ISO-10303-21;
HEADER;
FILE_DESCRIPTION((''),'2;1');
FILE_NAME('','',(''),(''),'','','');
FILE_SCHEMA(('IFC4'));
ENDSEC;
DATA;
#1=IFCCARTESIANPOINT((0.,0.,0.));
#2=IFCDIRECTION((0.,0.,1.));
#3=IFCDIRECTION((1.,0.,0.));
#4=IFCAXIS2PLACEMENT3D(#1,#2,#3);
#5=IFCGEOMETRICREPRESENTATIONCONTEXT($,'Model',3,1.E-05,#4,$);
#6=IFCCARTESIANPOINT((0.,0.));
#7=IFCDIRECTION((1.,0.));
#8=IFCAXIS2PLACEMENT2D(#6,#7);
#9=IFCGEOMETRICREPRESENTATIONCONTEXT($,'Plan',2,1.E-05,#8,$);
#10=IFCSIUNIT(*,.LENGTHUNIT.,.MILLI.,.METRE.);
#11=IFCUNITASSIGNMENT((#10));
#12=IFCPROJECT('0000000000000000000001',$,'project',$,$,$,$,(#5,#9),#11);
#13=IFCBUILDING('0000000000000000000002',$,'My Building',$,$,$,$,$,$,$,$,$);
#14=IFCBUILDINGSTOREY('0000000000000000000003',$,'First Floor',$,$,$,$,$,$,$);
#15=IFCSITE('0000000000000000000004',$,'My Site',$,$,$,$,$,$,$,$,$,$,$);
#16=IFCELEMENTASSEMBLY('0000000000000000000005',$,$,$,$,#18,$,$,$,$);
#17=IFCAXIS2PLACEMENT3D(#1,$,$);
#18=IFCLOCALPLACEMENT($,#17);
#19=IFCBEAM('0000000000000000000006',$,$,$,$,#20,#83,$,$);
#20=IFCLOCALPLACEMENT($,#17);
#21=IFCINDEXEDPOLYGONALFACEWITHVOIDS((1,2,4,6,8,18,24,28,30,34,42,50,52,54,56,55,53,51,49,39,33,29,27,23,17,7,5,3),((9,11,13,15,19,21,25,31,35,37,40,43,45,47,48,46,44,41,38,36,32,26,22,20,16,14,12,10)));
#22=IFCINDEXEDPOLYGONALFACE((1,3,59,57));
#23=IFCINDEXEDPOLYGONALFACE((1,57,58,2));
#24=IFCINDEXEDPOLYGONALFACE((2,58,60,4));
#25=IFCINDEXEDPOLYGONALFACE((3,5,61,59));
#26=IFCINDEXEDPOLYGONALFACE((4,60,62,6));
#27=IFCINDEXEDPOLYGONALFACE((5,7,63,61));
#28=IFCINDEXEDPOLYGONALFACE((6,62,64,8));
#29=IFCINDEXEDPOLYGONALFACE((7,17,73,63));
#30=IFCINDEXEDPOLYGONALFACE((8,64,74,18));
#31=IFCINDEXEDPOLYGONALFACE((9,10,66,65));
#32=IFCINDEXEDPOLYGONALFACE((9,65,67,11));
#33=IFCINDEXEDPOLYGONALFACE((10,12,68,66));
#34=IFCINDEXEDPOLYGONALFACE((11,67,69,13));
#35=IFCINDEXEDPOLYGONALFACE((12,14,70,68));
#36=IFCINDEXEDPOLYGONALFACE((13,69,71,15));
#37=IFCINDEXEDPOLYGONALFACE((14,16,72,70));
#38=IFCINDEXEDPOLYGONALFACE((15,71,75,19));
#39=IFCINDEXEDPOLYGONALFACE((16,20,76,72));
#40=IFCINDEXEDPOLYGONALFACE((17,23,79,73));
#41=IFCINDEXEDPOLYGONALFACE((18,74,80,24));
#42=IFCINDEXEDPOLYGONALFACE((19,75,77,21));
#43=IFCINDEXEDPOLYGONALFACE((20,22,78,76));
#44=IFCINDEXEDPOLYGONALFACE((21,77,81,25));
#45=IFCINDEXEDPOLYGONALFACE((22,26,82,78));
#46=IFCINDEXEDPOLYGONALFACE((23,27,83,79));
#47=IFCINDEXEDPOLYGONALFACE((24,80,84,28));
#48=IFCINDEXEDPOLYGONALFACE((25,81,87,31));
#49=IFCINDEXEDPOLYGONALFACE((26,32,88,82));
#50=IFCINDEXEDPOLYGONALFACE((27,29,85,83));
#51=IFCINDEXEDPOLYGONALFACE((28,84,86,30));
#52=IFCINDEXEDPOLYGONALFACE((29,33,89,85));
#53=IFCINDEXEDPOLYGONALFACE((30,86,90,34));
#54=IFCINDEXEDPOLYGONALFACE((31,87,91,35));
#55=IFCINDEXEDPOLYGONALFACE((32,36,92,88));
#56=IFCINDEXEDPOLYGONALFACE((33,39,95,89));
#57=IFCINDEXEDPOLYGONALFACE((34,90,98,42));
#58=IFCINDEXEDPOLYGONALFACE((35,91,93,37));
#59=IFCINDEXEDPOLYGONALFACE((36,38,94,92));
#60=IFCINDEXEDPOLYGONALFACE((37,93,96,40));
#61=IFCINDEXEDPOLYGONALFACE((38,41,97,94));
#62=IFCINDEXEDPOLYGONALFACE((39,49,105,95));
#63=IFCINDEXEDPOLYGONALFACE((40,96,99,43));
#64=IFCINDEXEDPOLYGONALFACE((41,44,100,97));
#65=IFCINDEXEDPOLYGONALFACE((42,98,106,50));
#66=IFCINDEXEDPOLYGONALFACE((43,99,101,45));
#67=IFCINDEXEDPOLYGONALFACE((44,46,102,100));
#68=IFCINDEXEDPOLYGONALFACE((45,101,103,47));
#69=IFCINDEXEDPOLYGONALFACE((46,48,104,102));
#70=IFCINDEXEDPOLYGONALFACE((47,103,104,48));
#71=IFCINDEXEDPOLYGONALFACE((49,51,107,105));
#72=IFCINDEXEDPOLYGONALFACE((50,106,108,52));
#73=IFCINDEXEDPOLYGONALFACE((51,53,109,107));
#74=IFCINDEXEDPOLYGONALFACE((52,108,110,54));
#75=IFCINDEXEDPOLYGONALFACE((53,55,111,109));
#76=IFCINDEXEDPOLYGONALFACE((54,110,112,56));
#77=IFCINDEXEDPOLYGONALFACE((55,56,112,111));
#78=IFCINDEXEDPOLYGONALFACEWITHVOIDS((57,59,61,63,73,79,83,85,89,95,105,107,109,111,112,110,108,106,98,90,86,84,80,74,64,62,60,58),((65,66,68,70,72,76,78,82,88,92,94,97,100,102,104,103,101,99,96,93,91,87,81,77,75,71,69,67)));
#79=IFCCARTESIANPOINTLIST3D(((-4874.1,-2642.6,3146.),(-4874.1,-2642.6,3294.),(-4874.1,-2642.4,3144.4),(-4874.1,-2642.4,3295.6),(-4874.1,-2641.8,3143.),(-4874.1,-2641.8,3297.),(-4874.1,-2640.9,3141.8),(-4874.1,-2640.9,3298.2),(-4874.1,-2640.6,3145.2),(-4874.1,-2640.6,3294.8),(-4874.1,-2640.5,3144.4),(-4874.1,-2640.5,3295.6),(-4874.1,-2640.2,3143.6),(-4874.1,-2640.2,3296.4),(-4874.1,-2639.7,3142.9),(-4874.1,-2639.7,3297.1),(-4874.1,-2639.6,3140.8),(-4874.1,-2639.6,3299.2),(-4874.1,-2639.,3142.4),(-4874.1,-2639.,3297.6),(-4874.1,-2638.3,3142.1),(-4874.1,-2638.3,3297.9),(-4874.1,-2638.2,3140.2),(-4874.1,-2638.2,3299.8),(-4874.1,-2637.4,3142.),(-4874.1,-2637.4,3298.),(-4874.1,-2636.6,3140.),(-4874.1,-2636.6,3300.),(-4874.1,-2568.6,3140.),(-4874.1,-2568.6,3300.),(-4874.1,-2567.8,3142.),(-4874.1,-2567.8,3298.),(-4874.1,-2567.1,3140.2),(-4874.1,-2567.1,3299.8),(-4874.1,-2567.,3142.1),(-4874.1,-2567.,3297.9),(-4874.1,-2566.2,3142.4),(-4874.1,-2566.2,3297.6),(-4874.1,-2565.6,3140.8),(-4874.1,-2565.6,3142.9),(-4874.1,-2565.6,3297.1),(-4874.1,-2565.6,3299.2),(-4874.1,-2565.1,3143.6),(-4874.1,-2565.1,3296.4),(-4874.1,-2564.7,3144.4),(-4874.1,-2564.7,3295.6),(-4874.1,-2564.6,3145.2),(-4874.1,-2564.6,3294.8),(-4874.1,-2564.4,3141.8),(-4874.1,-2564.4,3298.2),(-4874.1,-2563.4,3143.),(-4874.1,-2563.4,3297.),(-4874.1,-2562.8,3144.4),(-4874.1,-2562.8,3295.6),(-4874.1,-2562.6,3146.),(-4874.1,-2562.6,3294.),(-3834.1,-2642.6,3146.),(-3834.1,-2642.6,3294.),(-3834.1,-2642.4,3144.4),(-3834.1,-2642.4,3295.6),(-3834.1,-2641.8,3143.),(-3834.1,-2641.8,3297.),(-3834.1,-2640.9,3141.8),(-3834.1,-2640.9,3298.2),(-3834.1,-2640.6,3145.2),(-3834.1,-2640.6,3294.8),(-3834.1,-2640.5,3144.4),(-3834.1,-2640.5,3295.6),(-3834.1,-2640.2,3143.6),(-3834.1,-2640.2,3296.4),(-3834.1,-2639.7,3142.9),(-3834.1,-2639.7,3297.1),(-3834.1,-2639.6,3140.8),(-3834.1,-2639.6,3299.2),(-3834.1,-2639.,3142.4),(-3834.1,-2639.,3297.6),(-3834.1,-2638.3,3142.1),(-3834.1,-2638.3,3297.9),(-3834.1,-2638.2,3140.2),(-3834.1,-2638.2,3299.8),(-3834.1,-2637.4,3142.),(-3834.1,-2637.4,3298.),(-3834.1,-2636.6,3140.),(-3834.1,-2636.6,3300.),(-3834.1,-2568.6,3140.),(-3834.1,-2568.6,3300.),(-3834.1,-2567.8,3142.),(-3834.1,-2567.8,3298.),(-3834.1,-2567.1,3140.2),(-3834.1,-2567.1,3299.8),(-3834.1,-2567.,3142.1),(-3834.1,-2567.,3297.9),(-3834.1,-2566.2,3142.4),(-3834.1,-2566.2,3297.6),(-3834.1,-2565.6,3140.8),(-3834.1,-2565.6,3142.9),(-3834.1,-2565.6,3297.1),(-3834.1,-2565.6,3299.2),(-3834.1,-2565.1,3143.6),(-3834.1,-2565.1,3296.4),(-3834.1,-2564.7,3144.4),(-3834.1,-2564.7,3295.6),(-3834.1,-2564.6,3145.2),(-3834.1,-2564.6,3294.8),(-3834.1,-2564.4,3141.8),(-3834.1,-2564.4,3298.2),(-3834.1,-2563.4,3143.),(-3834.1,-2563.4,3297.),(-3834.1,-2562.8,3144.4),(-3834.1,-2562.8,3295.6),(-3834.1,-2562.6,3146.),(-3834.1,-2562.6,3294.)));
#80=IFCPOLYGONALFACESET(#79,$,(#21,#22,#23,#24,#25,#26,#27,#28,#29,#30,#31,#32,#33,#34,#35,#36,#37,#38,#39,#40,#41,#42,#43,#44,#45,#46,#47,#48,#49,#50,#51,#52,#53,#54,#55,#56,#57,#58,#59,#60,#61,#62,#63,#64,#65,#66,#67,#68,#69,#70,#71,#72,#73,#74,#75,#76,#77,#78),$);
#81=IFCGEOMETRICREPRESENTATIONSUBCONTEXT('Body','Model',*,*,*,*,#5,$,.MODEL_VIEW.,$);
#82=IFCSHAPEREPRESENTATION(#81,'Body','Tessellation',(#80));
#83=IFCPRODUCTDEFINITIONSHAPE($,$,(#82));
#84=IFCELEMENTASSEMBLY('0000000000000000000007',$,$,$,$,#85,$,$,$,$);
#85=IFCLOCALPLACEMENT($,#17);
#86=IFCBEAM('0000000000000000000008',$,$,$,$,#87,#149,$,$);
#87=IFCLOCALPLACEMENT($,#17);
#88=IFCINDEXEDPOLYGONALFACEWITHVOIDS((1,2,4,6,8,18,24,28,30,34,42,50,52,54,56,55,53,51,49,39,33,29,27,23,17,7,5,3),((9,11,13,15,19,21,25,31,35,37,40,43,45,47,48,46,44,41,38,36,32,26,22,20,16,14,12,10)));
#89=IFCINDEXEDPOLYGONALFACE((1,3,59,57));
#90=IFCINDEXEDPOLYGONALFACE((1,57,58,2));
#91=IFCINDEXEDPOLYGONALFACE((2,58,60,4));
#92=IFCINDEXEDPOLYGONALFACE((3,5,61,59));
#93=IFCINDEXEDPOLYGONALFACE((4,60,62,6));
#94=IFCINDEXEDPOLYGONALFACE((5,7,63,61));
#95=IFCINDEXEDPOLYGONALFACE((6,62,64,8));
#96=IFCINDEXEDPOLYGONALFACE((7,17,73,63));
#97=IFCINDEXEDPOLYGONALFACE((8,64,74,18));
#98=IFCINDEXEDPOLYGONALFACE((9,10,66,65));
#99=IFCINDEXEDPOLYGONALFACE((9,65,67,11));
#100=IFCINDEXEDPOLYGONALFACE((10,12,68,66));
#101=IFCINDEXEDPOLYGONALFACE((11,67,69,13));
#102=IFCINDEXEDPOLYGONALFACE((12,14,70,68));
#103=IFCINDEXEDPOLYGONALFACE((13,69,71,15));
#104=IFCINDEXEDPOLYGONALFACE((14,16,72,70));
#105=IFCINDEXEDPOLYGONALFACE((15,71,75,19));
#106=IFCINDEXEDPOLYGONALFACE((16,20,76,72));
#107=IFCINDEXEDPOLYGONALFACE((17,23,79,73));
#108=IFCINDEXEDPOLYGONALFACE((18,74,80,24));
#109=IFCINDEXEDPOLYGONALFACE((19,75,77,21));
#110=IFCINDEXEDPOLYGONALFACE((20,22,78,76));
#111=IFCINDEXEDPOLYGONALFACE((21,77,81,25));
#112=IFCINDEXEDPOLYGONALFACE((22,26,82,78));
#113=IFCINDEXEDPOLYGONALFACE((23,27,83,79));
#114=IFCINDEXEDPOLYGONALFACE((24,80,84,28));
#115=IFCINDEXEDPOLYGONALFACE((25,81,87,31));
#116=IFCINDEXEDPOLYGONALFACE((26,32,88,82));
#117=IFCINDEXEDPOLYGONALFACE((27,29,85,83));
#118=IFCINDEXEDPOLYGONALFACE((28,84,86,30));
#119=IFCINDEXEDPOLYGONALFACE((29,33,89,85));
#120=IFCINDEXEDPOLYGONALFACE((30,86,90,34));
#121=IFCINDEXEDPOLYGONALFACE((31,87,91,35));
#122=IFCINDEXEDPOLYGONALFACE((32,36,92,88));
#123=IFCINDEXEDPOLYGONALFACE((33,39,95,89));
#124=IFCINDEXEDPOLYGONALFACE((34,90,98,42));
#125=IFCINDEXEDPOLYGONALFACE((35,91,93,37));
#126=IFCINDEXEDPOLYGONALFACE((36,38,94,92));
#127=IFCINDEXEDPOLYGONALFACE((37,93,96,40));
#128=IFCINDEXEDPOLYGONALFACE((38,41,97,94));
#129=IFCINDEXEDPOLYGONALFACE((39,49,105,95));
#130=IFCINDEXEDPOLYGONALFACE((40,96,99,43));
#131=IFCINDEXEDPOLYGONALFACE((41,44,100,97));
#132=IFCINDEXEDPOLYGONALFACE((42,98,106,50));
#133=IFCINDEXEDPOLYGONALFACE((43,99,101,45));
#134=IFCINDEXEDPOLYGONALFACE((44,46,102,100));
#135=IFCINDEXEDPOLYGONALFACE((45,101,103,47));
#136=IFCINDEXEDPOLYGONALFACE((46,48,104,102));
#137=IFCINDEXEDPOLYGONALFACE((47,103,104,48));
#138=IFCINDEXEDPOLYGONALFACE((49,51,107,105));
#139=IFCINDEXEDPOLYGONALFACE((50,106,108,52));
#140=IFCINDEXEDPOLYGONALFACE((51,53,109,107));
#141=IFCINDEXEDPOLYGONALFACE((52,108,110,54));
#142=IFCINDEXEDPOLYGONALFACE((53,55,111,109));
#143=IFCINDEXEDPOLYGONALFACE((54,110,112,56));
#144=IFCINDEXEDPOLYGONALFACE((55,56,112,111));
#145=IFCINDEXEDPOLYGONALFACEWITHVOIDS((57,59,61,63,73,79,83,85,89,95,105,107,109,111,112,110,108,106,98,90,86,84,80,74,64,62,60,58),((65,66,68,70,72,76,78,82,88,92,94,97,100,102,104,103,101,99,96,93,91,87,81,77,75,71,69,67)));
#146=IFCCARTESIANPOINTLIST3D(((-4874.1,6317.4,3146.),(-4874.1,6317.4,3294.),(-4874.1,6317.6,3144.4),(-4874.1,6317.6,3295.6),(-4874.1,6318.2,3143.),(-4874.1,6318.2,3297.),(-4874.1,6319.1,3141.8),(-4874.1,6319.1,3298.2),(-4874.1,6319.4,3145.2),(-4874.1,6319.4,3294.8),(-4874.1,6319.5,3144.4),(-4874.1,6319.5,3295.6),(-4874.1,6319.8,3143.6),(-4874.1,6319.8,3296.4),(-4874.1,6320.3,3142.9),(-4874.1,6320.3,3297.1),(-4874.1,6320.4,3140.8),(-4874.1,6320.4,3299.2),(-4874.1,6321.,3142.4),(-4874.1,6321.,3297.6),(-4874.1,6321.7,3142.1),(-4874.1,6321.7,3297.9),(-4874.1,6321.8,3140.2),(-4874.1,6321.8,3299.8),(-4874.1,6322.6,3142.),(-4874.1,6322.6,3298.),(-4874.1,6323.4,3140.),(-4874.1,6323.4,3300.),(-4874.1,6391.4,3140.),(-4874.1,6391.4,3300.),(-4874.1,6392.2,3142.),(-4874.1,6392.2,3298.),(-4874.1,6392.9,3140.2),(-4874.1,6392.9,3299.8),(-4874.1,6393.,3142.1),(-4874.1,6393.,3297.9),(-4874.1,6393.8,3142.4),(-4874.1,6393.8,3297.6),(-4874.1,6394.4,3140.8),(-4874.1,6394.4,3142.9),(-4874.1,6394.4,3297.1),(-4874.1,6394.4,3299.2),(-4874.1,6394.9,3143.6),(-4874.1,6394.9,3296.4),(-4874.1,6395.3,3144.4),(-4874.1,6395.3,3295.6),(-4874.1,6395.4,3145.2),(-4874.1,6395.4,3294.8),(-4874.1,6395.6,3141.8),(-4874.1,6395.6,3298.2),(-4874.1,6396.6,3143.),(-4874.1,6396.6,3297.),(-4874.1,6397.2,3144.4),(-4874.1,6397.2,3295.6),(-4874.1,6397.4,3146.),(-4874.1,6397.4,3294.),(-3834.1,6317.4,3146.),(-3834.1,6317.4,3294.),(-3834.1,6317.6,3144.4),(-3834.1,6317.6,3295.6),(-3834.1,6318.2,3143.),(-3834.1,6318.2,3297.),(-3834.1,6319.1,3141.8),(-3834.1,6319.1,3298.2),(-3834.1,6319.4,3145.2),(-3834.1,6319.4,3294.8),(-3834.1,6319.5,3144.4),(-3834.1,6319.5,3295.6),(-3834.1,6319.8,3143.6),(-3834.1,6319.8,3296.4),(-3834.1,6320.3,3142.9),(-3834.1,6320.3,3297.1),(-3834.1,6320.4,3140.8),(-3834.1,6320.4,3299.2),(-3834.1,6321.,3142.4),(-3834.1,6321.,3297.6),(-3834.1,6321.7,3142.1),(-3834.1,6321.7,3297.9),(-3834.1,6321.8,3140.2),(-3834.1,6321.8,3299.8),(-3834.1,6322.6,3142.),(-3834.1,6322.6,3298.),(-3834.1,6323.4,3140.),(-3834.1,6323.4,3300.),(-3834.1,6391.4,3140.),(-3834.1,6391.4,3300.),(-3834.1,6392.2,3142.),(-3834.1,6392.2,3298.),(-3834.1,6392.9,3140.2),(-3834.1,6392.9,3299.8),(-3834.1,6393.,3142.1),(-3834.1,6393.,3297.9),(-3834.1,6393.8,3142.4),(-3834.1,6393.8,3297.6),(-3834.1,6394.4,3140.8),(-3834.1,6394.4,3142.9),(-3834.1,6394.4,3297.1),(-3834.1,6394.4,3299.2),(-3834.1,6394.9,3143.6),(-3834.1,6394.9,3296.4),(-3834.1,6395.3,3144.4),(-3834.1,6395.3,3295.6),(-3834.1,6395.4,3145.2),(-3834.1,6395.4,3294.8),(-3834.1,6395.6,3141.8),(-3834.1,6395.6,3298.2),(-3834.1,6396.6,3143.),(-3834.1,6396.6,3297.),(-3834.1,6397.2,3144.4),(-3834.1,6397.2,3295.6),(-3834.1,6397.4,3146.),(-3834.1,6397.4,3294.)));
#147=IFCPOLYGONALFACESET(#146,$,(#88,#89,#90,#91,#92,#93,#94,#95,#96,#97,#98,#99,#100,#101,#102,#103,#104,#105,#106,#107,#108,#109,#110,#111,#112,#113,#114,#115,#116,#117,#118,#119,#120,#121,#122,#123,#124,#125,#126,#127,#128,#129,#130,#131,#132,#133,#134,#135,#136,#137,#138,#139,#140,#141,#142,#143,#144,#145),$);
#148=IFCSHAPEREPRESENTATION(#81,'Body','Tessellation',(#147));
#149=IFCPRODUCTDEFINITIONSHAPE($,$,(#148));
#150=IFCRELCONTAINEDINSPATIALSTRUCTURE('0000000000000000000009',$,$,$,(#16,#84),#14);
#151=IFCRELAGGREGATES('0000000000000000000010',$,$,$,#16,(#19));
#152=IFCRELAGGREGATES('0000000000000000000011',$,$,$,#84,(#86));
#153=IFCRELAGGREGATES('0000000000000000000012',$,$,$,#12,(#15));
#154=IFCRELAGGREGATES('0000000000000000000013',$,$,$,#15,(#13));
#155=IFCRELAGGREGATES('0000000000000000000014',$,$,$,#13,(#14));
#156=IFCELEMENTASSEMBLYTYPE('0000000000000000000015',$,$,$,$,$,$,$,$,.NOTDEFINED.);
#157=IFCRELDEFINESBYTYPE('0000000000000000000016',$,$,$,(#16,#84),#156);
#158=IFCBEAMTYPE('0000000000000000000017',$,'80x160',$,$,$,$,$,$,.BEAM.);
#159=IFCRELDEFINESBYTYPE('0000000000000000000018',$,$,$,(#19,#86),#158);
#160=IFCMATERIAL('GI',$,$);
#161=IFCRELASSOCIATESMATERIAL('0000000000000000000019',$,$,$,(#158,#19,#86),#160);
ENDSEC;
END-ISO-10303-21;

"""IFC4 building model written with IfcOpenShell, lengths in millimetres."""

from ifc_helpers import new_model, si_unit, frame, origin_with_axes, origin_2d_with_axis, place, context, subcontext, project, spatial, hollow_rectangle, extrude, material, material_profile, profile_set, profile_usage, type_object, element, aggregate, save


model = new_model("IFC4")

# Units and contexts
model_context = context("Model", 3, precision=1e-05, world=origin_with_axes())
plan_context = context("Plan", 2, precision=1e-05, world=origin_2d_with_axis())
body_context = subcontext(model_context, "Body", "Model", "MODEL_VIEW")
ifc_project = project(units=[si_unit("LENGTHUNIT", "METRE", prefix="MILLI")], contexts=[model_context, plan_context])

# Site, building, storey
site = spatial("IfcSite", under=ifc_project, Name="My Site")
building = spatial("IfcBuilding", under=site, Name="My Building")
storey = spatial("IfcBuildingStorey", under=building, Name="First Floor")

# Element assemblies, beams
element_assembly_type = type_object("IfcElementAssemblyType", PredefinedType="NOTDEFINED")
ifc_material = material(Name="GI")
ifc_material_profile = material_profile(ifc_material, hollow_rectangle(XDim=80.0, YDim=160.0, WallThickness=2.0, InnerFilletRadius=3.2, OuterFilletRadius=6.0))
ifc_profile_set = profile_set([ifc_material_profile], Name="80x160 GI Rectangular Hollow")
beam_type = type_object("IfcBeamType", Name="80x160", PredefinedType="BEAM", material=ifc_profile_set)
assembly_1_placement = place(None, frame((-4954.1, -2602.6, 3220.0), z_axis=(1.0, 0.0, 0.0), x_axis=(0.0, 1.0, 0.0)))
assembly_1 = element("IfcElementAssembly", 1, at=assembly_1_placement, inside=storey, type_object=element_assembly_type)
ifc_profile_usage_1 = profile_usage(ifc_profile_set)
beam_1_placement = place(assembly_1_placement, frame((0.0, 0.0, 80.0), z_axis=(0.0, 0.0, 1.0), x_axis=(1.0, 0.0, 0.0)))
beam_1 = element("IfcBeam", 2, at=beam_1_placement, type_object=beam_type, material=ifc_profile_usage_1, context=body_context, shape_type="SweptSolid", body=[
    extrude(hollow_rectangle(XDim=80.0, YDim=160.0, WallThickness=2.0, InnerFilletRadius=3.2, OuterFilletRadius=6.0), origin_with_axes(), (0.0, 0.0, 1.0), 1040.0),
])
aggregate(assembly_1, [beam_1])
assembly_2_placement = place(None, frame((-4954.1, 6357.4, 3220.0), z_axis=(1.0, 0.0, 0.0), x_axis=(0.0, 1.0, 0.0)))
assembly_2 = element("IfcElementAssembly", 3, at=assembly_2_placement, inside=storey, type_object=element_assembly_type)
ifc_profile_usage_2 = profile_usage(ifc_profile_set)
beam_2_placement = place(assembly_2_placement, frame((0.0, 0.0, 80.0), z_axis=(0.0, 0.0, 1.0), x_axis=(1.0, 0.0, 0.0)))
beam_2 = element("IfcBeam", 4, at=beam_2_placement, type_object=beam_type, material=ifc_profile_usage_2, context=body_context, shape_type="SweptSolid", body=[
    extrude(hollow_rectangle(XDim=80.0, YDim=160.0, WallThickness=2.0, InnerFilletRadius=3.2, OuterFilletRadius=6.0), origin_with_axes(), (0.0, 0.0, 1.0), 1040.0),
])
aggregate(assembly_2, [beam_2])

save(model, "model.ifc")
